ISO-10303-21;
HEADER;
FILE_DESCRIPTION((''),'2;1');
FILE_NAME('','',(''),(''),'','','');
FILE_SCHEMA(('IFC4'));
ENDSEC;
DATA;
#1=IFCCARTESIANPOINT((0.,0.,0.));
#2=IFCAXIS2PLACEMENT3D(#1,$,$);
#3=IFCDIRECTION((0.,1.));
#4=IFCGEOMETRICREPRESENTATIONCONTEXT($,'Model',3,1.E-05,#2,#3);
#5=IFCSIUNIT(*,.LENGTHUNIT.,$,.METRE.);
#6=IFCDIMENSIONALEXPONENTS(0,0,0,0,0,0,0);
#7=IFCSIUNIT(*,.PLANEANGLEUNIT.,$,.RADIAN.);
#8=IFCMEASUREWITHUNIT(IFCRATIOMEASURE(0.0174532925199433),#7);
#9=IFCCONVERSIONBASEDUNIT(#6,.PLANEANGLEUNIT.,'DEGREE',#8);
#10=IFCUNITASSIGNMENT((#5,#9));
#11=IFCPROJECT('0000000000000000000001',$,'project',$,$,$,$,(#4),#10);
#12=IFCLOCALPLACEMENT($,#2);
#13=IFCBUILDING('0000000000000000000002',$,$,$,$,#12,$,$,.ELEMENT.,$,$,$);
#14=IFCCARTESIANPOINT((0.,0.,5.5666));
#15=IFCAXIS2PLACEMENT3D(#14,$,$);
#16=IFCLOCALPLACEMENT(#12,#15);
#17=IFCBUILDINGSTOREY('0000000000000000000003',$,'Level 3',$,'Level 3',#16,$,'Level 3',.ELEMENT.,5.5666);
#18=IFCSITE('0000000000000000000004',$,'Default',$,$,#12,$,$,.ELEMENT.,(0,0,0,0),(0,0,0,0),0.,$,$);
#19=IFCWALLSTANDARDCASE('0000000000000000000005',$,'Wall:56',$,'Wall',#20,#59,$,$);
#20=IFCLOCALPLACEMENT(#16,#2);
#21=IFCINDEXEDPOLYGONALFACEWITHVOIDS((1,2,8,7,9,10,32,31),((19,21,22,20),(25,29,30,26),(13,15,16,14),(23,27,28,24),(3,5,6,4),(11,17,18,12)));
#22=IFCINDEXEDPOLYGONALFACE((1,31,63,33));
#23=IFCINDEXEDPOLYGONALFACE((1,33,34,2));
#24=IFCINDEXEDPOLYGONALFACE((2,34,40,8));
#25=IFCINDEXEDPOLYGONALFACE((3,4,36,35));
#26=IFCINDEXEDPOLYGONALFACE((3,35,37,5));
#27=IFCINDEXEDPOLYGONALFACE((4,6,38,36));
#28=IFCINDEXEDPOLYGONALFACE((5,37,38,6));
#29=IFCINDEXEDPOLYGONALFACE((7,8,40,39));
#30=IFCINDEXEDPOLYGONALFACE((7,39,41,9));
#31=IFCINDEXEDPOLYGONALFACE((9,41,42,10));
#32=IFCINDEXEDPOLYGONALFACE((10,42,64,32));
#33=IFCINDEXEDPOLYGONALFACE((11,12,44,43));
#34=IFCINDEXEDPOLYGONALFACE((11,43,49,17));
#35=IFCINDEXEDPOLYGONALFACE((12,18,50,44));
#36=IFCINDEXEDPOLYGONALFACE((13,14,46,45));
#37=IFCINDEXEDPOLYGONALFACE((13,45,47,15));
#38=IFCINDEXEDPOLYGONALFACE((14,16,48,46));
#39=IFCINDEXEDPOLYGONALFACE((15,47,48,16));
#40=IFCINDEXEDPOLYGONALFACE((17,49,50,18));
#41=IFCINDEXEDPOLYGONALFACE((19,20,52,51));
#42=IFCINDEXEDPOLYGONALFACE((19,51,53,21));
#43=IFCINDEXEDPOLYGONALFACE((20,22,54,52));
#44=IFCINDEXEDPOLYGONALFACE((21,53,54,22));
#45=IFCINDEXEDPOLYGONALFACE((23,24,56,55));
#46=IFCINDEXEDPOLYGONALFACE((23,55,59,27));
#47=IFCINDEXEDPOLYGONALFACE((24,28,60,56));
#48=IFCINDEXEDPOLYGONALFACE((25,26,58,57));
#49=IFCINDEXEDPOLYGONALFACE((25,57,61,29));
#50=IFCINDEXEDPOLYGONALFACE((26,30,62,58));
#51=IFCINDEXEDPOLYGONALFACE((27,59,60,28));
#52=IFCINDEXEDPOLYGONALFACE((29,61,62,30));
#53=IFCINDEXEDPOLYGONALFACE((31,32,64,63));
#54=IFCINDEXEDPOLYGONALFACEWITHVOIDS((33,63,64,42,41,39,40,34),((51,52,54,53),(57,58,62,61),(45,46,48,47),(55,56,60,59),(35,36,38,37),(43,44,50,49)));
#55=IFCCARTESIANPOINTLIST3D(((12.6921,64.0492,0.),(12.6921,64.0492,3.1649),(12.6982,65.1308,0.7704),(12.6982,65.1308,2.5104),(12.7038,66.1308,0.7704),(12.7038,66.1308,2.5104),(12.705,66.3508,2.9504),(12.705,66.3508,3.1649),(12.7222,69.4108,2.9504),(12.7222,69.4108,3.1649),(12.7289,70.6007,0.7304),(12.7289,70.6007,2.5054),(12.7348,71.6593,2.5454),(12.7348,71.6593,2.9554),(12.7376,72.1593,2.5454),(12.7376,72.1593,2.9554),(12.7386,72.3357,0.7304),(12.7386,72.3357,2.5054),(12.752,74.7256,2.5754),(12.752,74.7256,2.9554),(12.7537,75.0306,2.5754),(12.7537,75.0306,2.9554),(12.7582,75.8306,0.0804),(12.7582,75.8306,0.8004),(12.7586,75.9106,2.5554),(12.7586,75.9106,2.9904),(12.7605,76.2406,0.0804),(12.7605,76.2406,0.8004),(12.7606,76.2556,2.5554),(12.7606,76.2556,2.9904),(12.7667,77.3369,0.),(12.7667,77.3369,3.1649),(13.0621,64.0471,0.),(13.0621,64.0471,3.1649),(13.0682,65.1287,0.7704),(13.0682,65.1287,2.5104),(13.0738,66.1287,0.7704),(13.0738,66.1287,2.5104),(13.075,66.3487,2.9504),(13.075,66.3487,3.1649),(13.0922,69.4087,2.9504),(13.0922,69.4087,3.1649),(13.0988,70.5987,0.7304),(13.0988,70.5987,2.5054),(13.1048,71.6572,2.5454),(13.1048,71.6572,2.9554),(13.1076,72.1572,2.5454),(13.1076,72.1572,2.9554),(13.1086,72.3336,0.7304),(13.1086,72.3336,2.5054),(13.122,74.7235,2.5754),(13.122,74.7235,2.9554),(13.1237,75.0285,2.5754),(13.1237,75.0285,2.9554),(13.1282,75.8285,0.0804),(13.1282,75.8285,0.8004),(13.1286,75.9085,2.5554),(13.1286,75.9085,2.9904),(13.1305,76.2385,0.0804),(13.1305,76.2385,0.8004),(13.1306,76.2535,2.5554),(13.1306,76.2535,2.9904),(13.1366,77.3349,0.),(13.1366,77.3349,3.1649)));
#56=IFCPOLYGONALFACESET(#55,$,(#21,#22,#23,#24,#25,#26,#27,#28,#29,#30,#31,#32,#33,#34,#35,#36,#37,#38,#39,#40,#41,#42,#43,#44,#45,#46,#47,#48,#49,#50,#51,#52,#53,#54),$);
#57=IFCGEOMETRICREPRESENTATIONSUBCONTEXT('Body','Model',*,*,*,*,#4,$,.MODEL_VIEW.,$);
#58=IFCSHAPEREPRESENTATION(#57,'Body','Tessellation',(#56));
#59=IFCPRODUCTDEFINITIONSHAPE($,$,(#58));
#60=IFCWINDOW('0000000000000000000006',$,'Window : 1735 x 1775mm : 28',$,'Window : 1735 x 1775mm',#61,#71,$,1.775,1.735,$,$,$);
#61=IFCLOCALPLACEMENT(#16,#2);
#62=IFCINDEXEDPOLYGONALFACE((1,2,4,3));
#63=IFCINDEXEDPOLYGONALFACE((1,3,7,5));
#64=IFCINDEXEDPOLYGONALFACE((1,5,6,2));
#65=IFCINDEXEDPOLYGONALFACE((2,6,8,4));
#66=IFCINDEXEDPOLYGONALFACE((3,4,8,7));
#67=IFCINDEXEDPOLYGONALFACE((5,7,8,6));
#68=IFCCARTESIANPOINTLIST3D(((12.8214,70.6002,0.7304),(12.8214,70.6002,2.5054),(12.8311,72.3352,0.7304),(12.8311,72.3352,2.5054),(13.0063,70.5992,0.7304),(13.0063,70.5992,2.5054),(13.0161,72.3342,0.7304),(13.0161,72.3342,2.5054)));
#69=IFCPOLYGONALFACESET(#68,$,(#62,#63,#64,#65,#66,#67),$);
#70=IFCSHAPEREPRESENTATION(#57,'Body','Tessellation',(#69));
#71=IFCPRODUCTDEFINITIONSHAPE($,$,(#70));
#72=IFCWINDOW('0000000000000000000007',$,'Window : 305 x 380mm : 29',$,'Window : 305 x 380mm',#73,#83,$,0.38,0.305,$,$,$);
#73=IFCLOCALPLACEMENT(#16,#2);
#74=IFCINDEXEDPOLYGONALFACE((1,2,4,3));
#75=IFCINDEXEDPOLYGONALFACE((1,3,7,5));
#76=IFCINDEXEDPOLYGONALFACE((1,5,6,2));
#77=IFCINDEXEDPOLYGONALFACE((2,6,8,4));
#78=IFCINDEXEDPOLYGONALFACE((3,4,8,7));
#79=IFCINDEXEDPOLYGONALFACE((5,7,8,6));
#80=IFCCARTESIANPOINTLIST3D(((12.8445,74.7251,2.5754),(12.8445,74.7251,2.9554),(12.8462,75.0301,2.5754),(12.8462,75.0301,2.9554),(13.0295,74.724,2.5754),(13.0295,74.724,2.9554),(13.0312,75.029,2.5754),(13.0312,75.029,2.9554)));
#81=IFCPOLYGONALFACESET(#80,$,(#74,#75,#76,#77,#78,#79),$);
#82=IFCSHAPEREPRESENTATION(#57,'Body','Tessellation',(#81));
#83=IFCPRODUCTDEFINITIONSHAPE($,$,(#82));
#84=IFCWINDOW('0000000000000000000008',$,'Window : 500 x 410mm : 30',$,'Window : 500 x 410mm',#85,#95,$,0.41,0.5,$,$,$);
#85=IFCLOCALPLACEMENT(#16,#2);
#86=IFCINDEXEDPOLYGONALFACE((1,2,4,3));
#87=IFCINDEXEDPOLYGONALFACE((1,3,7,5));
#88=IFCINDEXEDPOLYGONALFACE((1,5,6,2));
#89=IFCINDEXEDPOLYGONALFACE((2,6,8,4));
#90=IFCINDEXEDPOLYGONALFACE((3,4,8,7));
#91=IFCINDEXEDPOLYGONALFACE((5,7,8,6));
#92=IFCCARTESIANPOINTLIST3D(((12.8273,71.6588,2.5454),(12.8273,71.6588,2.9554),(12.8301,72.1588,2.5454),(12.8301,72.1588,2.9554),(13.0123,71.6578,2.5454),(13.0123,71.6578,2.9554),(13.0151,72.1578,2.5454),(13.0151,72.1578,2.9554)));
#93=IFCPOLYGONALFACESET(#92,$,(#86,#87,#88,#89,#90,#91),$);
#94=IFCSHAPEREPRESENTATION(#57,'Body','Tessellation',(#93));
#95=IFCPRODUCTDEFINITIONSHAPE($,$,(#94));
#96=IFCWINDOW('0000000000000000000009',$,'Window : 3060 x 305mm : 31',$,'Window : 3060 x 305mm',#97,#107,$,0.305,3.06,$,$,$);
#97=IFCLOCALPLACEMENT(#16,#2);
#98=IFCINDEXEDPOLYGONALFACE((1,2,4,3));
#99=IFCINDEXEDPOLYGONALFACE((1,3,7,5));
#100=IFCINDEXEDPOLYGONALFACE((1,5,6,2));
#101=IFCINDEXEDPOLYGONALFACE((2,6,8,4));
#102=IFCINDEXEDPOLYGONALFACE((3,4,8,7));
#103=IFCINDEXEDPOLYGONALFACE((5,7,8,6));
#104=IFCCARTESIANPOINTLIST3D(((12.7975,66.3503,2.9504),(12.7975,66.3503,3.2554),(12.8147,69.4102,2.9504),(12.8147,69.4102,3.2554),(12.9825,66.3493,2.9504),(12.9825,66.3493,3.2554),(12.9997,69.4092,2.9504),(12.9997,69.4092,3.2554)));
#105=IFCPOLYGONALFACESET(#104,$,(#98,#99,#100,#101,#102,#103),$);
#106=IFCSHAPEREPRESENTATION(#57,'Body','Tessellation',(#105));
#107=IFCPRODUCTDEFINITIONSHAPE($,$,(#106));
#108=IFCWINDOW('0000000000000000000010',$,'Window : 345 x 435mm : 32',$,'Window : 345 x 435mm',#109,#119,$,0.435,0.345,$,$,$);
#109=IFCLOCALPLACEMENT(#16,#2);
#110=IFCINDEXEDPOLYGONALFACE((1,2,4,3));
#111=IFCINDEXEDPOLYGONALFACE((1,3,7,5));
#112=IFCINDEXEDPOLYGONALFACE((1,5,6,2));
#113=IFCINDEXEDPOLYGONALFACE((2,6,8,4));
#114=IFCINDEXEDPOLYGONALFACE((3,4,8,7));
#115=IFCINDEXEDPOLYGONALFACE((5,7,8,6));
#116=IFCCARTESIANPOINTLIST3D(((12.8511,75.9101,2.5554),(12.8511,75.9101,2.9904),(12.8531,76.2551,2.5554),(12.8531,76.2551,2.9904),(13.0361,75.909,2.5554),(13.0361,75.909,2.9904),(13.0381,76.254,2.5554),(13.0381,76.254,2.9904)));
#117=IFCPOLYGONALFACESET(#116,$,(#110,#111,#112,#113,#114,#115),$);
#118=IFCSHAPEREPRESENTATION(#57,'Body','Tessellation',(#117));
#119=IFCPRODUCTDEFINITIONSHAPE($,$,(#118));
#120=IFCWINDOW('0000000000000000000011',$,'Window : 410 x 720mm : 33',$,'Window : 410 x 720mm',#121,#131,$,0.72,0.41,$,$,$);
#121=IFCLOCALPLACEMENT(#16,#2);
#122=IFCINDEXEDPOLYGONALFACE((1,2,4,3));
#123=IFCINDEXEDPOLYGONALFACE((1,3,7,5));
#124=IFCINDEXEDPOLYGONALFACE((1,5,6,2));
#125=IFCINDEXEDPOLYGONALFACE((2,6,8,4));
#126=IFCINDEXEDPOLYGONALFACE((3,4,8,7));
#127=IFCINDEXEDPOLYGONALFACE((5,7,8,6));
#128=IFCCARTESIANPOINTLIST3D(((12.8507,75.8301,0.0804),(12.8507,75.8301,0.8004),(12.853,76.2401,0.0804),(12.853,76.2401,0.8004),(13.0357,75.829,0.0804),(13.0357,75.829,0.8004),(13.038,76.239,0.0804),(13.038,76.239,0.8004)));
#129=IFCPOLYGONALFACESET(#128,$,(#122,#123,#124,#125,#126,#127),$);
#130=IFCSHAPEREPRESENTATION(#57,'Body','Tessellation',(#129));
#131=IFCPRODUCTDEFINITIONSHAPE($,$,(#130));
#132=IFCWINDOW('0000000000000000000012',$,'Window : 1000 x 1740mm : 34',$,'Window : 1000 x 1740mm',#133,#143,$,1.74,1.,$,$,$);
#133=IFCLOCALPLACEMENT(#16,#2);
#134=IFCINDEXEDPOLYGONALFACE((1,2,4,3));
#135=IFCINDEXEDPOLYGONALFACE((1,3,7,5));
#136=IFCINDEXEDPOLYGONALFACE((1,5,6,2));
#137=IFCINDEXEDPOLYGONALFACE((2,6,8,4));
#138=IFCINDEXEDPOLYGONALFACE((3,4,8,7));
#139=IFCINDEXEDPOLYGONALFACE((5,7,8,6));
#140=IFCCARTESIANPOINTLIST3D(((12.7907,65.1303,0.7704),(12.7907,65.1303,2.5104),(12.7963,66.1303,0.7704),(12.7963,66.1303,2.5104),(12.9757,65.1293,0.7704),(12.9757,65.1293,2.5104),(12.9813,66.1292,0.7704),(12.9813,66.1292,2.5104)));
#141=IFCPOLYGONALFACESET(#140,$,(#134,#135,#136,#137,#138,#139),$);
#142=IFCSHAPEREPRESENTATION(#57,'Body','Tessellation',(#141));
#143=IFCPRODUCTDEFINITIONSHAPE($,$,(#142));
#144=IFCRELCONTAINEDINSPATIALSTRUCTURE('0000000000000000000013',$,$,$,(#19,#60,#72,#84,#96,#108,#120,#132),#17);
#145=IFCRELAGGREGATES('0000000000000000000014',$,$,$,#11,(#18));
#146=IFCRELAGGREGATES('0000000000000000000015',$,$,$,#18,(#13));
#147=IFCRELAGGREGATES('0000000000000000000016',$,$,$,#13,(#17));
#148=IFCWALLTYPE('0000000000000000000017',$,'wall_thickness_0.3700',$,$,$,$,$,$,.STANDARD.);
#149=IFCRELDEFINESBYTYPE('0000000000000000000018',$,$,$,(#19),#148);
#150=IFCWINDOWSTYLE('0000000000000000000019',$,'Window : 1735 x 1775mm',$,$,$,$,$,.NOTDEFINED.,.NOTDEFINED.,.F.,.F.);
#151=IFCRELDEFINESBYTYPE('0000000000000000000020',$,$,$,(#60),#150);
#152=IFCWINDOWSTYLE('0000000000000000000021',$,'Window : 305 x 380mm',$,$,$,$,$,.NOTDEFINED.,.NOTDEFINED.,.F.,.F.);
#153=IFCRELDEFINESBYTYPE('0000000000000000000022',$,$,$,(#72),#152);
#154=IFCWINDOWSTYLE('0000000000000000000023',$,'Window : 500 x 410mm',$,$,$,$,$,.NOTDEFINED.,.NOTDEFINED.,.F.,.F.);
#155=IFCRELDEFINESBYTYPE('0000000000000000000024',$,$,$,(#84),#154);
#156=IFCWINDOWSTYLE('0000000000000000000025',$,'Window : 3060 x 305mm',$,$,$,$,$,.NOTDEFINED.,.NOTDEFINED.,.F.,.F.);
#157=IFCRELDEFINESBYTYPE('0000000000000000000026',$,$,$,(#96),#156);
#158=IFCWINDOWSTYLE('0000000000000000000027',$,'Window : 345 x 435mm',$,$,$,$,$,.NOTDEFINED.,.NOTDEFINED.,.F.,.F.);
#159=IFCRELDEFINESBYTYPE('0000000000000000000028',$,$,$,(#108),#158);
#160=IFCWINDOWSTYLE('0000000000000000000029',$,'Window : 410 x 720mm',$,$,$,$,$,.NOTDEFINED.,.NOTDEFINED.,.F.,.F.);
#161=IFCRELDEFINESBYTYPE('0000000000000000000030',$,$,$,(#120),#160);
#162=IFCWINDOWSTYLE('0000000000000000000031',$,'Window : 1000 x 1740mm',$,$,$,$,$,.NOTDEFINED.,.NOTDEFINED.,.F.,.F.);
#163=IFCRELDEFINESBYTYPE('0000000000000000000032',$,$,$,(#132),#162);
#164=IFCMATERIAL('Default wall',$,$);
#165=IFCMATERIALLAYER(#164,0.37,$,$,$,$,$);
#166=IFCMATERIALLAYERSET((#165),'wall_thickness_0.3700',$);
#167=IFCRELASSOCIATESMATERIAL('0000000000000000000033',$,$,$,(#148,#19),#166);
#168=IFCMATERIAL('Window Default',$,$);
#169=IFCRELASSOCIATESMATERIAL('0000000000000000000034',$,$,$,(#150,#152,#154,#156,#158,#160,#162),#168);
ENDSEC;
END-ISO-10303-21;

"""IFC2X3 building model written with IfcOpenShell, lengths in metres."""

from ifc_helpers import new_model, entity, si_unit, converted_unit, direction, frame, frame_2d, origin, origin_2d_with_axis, place, context, subcontext, project, spatial, polyline, rectangle, outline, extrude, source, transform, mapped, material, layer, layer_set, layer_usage, type_object, type_shapes, element, fill, save


model = new_model("IFC2X3")

# Units and contexts
model_context = context("Model", 3, precision=1e-05, world=origin(), true_north=direction((0.0, 1.0)))
body_context = subcontext(model_context, "Body", "Model", "MODEL_VIEW")
ifc_project = project(units=[si_unit("LENGTHUNIT", "METRE"), converted_unit("PLANEANGLEUNIT", "DEGREE", entity("IfcRatioMeasure", 0.0174532925199433), si_unit("PLANEANGLEUNIT", "RADIAN"), dimensions=[0, 0, 0, 0, 0, 0, 0])], contexts=[model_context])

# Site, building, storey
placement_1 = place(None, origin())
site = spatial("IfcSite", under=ifc_project, at=placement_1, Name="Default", CompositionType="ELEMENT", RefLatitude=(0, 0, 0, 0), RefLongitude=(0, 0, 0, 0), RefElevation=0.0)
building = spatial("IfcBuilding", under=site, at=placement_1, CompositionType="ELEMENT")
storey_placement = place(placement_1, frame((0.0, 0.0, 5.5666)))
storey = spatial("IfcBuildingStorey", under=building, at=storey_placement, Name="Level 3", ObjectType="Level 3", LongName="Level 3", CompositionType="ELEMENT", Elevation=5.5666)

# Shared definitions
ifc_material_1 = material(Name="Default wall")
ifc_material_2 = material(Name="Window Default")

# Wall, openings, windows
ifc_layer_1 = layer(ifc_material_1, 0.37)
ifc_layer_set_1 = layer_set([ifc_layer_1], Name="wall_thickness_0.3700")
ifc_layer_usage_1 = layer_usage(ifc_layer_set_1, "AXIS2", "POSITIVE", -0.185)
wall_type_1 = type_object("IfcWallType", Name="wall_thickness_0.3700", PredefinedType="STANDARD", material=ifc_layer_set_1)
wall_1_placement = place(storey_placement, frame((12.9516, 77.3359, 0.0), z_axis=(0.0, 0.0, 1.0), x_axis=(-0.005611, -0.999984, 0.0)))
wall_1 = element("IfcWallStandardCase", 1, at=wall_1_placement, inside=storey, type_object=wall_type_1, material=ifc_layer_usage_1, Name="Wall:56", ObjectType="Wall", context=body_context, shape_type="SweptSolid", body=[
    extrude(outline(polyline([(13.288, -0.185), (13.288, 0.185), (0.0, 0.185), (0.0, -0.185), (13.288, -0.185)])), origin(), (0.0, 0.0, 1.0), 3.1649),
])
opening_1_placement = place(wall_1_placement, frame((5.0013, -0.185, 0.7304)))
opening_1 = element("IfcOpeningElement", 2, at=opening_1_placement, cuts=wall_1, ObjectType="Opening", context=body_context, shape_type="SweptSolid", body=[
    extrude(rectangle(XDim=1.735, YDim=1.775, at=frame_2d((0.8875, 0.8675), x_axis=(0.0, 1.0))), frame((0.0, 0.0, 0.0), z_axis=(0.0, 1.0, 0.0), x_axis=(0.0, 0.0, 1.0)), (0.0, 0.0, 1.0), 0.37),
])
opening_2_placement = place(wall_1_placement, frame((2.3064, -0.185, 2.5754)))
opening_2 = element("IfcOpeningElement", 3, at=opening_2_placement, cuts=wall_1, ObjectType="Opening", context=body_context, shape_type="SweptSolid", body=[
    extrude(rectangle(XDim=0.305, YDim=0.38, at=frame_2d((0.19, 0.1525), x_axis=(0.0, 1.0))), frame((0.0, 0.0, 0.0), z_axis=(0.0, 1.0, 0.0), x_axis=(0.0, 0.0, 1.0)), (0.0, 0.0, 1.0), 0.37),
])
opening_3_placement = place(wall_1_placement, frame((5.1777, -0.185, 2.5454)))
opening_3 = element("IfcOpeningElement", 4, at=opening_3_placement, cuts=wall_1, ObjectType="Opening", context=body_context, shape_type="SweptSolid", body=[
    extrude(rectangle(XDim=0.5, YDim=0.41, at=frame_2d((0.205, 0.25), x_axis=(0.0, 1.0))), frame((0.0, 0.0, 0.0), z_axis=(0.0, 1.0, 0.0), x_axis=(0.0, 0.0, 1.0)), (0.0, 0.0, 1.0), 0.37),
])
opening_4_placement = place(wall_1_placement, frame((7.9263, -0.185, 2.9504)))
opening_4 = element("IfcOpeningElement", 5, at=opening_4_placement, cuts=wall_1, ObjectType="Opening", context=body_context, shape_type="SweptSolid", body=[
    extrude(rectangle(XDim=3.06, YDim=0.305, at=frame_2d((0.1525, 1.53), x_axis=(0.0, 1.0))), frame((0.0, 0.0, 0.0), z_axis=(0.0, 1.0, 0.0), x_axis=(0.0, 0.0, 1.0)), (0.0, 0.0, 1.0), 0.37),
])
opening_5_placement = place(wall_1_placement, frame((1.0814, -0.185, 2.5554)))
opening_5 = element("IfcOpeningElement", 6, at=opening_5_placement, cuts=wall_1, ObjectType="Opening", context=body_context, shape_type="SweptSolid", body=[
    extrude(rectangle(XDim=0.345, YDim=0.435, at=frame_2d((0.2175, 0.1725), x_axis=(0.0, 1.0))), frame((0.0, 0.0, 0.0), z_axis=(0.0, 1.0, 0.0), x_axis=(0.0, 0.0, 1.0)), (0.0, 0.0, 1.0), 0.37),
])
opening_6_placement = place(wall_1_placement, frame((1.0964, -0.185, 0.0804)))
opening_6 = element("IfcOpeningElement", 7, at=opening_6_placement, cuts=wall_1, ObjectType="Opening", context=body_context, shape_type="SweptSolid", body=[
    extrude(rectangle(XDim=0.41, YDim=0.72, at=frame_2d((0.36, 0.205), x_axis=(0.0, 1.0))), frame((0.0, 0.0, 0.0), z_axis=(0.0, 1.0, 0.0), x_axis=(0.0, 0.0, 1.0)), (0.0, 0.0, 1.0), 0.37),
])
opening_7_placement = place(wall_1_placement, frame((11.2063, -0.185, 0.7704)))
opening_7 = element("IfcOpeningElement", 8, at=opening_7_placement, cuts=wall_1, ObjectType="Opening", context=body_context, shape_type="SweptSolid", body=[
    extrude(rectangle(XDim=1.0, YDim=1.74, at=frame_2d((0.87, 0.5), x_axis=(0.0, 1.0))), frame((0.0, 0.0, 0.0), z_axis=(0.0, 1.0, 0.0), x_axis=(0.0, 0.0, 1.0)), (0.0, 0.0, 1.0), 0.37),
])
window_style_1 = type_object("IfcWindowStyle", Name="Window : 1735 x 1775mm", ConstructionType="NOTDEFINED", OperationType="NOTDEFINED", ParameterTakesPrecedence=False, Sizeable=False, material=ifc_material_2)
shared_shape_1 = source(origin(), body_context, "Body", "SweptSolid", [
    extrude(rectangle(XDim=0.185, YDim=1.735, at=origin_2d_with_axis()), frame((0.8675, 0.185, 0.0), z_axis=(0.0, 0.0, 1.0), x_axis=(0.0, 1.0, 0.0)), (0.0, 0.0, 1.0), 1.775),
])
type_shapes(window_style_1, [shared_shape_1])
window_1_placement = place(opening_1_placement, origin())
window_1 = element("IfcWindow", 9, at=window_1_placement, inside=storey, type_object=window_style_1, Name="Window : 1735 x 1775mm : 28", ObjectType="Window : 1735 x 1775mm", OverallHeight=1.775, OverallWidth=1.735, context=body_context, shape_type="MappedRepresentation", body=[
    mapped(shared_shape_1, transform((0.0, 0.0, 0.0), scale=1.0)),
])
fill(opening_1, window_1)
window_style_2 = type_object("IfcWindowStyle", Name="Window : 305 x 380mm", ConstructionType="NOTDEFINED", OperationType="NOTDEFINED", ParameterTakesPrecedence=False, Sizeable=False, material=ifc_material_2)
shared_shape_2 = source(origin(), body_context, "Body", "SweptSolid", [
    extrude(rectangle(XDim=0.185, YDim=0.305, at=origin_2d_with_axis()), frame((0.1525, 0.185, 0.0), z_axis=(0.0, 0.0, 1.0), x_axis=(0.0, 1.0, 0.0)), (0.0, 0.0, 1.0), 0.38),
])
type_shapes(window_style_2, [shared_shape_2])
window_2_placement = place(opening_2_placement, origin())
window_2 = element("IfcWindow", 10, at=window_2_placement, inside=storey, type_object=window_style_2, Name="Window : 305 x 380mm : 29", ObjectType="Window : 305 x 380mm", OverallHeight=0.38, OverallWidth=0.305, context=body_context, shape_type="MappedRepresentation", body=[
    mapped(shared_shape_2, transform((0.0, 0.0, 0.0), scale=1.0)),
])
fill(opening_2, window_2)
window_style_3 = type_object("IfcWindowStyle", Name="Window : 500 x 410mm", ConstructionType="NOTDEFINED", OperationType="NOTDEFINED", ParameterTakesPrecedence=False, Sizeable=False, material=ifc_material_2)
shared_shape_3 = source(origin(), body_context, "Body", "SweptSolid", [
    extrude(rectangle(XDim=0.185, YDim=0.5, at=origin_2d_with_axis()), frame((0.25, 0.185, 0.0), z_axis=(0.0, 0.0, 1.0), x_axis=(0.0, 1.0, 0.0)), (0.0, 0.0, 1.0), 0.41),
])
type_shapes(window_style_3, [shared_shape_3])
window_3_placement = place(opening_3_placement, origin())
window_3 = element("IfcWindow", 11, at=window_3_placement, inside=storey, type_object=window_style_3, Name="Window : 500 x 410mm : 30", ObjectType="Window : 500 x 410mm", OverallHeight=0.41, OverallWidth=0.5, context=body_context, shape_type="MappedRepresentation", body=[
    mapped(shared_shape_3, transform((0.0, 0.0, 0.0), scale=1.0)),
])
fill(opening_3, window_3)
window_style_4 = type_object("IfcWindowStyle", Name="Window : 3060 x 305mm", ConstructionType="NOTDEFINED", OperationType="NOTDEFINED", ParameterTakesPrecedence=False, Sizeable=False, material=ifc_material_2)
shared_shape_4 = source(origin(), body_context, "Body", "SweptSolid", [
    extrude(rectangle(XDim=0.185, YDim=3.06, at=origin_2d_with_axis()), frame((1.53, 0.185, 0.0), z_axis=(0.0, 0.0, 1.0), x_axis=(0.0, 1.0, 0.0)), (0.0, 0.0, 1.0), 0.305),
])
type_shapes(window_style_4, [shared_shape_4])
window_4_placement = place(opening_4_placement, origin())
window_4 = element("IfcWindow", 12, at=window_4_placement, inside=storey, type_object=window_style_4, Name="Window : 3060 x 305mm : 31", ObjectType="Window : 3060 x 305mm", OverallHeight=0.305, OverallWidth=3.06, context=body_context, shape_type="MappedRepresentation", body=[
    mapped(shared_shape_4, transform((0.0, 0.0, 0.0), scale=1.0)),
])
fill(opening_4, window_4)
window_style_5 = type_object("IfcWindowStyle", Name="Window : 345 x 435mm", ConstructionType="NOTDEFINED", OperationType="NOTDEFINED", ParameterTakesPrecedence=False, Sizeable=False, material=ifc_material_2)
shared_shape_5 = source(origin(), body_context, "Body", "SweptSolid", [
    extrude(rectangle(XDim=0.185, YDim=0.345, at=origin_2d_with_axis()), frame((0.1725, 0.185, 0.0), z_axis=(0.0, 0.0, 1.0), x_axis=(0.0, 1.0, 0.0)), (0.0, 0.0, 1.0), 0.435),
])
type_shapes(window_style_5, [shared_shape_5])
window_5_placement = place(opening_5_placement, origin())
window_5 = element("IfcWindow", 13, at=window_5_placement, inside=storey, type_object=window_style_5, Name="Window : 345 x 435mm : 32", ObjectType="Window : 345 x 435mm", OverallHeight=0.435, OverallWidth=0.345, context=body_context, shape_type="MappedRepresentation", body=[
    mapped(shared_shape_5, transform((0.0, 0.0, 0.0), scale=1.0)),
])
fill(opening_5, window_5)
window_style_6 = type_object("IfcWindowStyle", Name="Window : 410 x 720mm", ConstructionType="NOTDEFINED", OperationType="NOTDEFINED", ParameterTakesPrecedence=False, Sizeable=False, material=ifc_material_2)
shared_shape_6 = source(origin(), body_context, "Body", "SweptSolid", [
    extrude(rectangle(XDim=0.185, YDim=0.41, at=origin_2d_with_axis()), frame((0.205, 0.185, 0.0), z_axis=(0.0, 0.0, 1.0), x_axis=(0.0, 1.0, 0.0)), (0.0, 0.0, 1.0), 0.72),
])
type_shapes(window_style_6, [shared_shape_6])
window_6_placement = place(opening_6_placement, origin())
window_6 = element("IfcWindow", 14, at=window_6_placement, inside=storey, type_object=window_style_6, Name="Window : 410 x 720mm : 33", ObjectType="Window : 410 x 720mm", OverallHeight=0.72, OverallWidth=0.41, context=body_context, shape_type="MappedRepresentation", body=[
    mapped(shared_shape_6, transform((0.0, 0.0, 0.0), scale=1.0)),
])
fill(opening_6, window_6)
window_style_7 = type_object("IfcWindowStyle", Name="Window : 1000 x 1740mm", ConstructionType="NOTDEFINED", OperationType="NOTDEFINED", ParameterTakesPrecedence=False, Sizeable=False, material=ifc_material_2)
shared_shape_7 = source(origin(), body_context, "Body", "SweptSolid", [
    extrude(rectangle(XDim=0.185, YDim=1.0, at=origin_2d_with_axis()), frame((0.5, 0.185, 0.0), z_axis=(0.0, 0.0, 1.0), x_axis=(0.0, 1.0, 0.0)), (0.0, 0.0, 1.0), 1.74),
])
type_shapes(window_style_7, [shared_shape_7])
window_7_placement = place(opening_7_placement, origin())
window_7 = element("IfcWindow", 15, at=window_7_placement, inside=storey, type_object=window_style_7, Name="Window : 1000 x 1740mm : 34", ObjectType="Window : 1000 x 1740mm", OverallHeight=1.74, OverallWidth=1.0, context=body_context, shape_type="MappedRepresentation", body=[
    mapped(shared_shape_7, transform((0.0, 0.0, 0.0), scale=1.0)),
])
fill(opening_7, window_7)

save(model, "model.ifc")
